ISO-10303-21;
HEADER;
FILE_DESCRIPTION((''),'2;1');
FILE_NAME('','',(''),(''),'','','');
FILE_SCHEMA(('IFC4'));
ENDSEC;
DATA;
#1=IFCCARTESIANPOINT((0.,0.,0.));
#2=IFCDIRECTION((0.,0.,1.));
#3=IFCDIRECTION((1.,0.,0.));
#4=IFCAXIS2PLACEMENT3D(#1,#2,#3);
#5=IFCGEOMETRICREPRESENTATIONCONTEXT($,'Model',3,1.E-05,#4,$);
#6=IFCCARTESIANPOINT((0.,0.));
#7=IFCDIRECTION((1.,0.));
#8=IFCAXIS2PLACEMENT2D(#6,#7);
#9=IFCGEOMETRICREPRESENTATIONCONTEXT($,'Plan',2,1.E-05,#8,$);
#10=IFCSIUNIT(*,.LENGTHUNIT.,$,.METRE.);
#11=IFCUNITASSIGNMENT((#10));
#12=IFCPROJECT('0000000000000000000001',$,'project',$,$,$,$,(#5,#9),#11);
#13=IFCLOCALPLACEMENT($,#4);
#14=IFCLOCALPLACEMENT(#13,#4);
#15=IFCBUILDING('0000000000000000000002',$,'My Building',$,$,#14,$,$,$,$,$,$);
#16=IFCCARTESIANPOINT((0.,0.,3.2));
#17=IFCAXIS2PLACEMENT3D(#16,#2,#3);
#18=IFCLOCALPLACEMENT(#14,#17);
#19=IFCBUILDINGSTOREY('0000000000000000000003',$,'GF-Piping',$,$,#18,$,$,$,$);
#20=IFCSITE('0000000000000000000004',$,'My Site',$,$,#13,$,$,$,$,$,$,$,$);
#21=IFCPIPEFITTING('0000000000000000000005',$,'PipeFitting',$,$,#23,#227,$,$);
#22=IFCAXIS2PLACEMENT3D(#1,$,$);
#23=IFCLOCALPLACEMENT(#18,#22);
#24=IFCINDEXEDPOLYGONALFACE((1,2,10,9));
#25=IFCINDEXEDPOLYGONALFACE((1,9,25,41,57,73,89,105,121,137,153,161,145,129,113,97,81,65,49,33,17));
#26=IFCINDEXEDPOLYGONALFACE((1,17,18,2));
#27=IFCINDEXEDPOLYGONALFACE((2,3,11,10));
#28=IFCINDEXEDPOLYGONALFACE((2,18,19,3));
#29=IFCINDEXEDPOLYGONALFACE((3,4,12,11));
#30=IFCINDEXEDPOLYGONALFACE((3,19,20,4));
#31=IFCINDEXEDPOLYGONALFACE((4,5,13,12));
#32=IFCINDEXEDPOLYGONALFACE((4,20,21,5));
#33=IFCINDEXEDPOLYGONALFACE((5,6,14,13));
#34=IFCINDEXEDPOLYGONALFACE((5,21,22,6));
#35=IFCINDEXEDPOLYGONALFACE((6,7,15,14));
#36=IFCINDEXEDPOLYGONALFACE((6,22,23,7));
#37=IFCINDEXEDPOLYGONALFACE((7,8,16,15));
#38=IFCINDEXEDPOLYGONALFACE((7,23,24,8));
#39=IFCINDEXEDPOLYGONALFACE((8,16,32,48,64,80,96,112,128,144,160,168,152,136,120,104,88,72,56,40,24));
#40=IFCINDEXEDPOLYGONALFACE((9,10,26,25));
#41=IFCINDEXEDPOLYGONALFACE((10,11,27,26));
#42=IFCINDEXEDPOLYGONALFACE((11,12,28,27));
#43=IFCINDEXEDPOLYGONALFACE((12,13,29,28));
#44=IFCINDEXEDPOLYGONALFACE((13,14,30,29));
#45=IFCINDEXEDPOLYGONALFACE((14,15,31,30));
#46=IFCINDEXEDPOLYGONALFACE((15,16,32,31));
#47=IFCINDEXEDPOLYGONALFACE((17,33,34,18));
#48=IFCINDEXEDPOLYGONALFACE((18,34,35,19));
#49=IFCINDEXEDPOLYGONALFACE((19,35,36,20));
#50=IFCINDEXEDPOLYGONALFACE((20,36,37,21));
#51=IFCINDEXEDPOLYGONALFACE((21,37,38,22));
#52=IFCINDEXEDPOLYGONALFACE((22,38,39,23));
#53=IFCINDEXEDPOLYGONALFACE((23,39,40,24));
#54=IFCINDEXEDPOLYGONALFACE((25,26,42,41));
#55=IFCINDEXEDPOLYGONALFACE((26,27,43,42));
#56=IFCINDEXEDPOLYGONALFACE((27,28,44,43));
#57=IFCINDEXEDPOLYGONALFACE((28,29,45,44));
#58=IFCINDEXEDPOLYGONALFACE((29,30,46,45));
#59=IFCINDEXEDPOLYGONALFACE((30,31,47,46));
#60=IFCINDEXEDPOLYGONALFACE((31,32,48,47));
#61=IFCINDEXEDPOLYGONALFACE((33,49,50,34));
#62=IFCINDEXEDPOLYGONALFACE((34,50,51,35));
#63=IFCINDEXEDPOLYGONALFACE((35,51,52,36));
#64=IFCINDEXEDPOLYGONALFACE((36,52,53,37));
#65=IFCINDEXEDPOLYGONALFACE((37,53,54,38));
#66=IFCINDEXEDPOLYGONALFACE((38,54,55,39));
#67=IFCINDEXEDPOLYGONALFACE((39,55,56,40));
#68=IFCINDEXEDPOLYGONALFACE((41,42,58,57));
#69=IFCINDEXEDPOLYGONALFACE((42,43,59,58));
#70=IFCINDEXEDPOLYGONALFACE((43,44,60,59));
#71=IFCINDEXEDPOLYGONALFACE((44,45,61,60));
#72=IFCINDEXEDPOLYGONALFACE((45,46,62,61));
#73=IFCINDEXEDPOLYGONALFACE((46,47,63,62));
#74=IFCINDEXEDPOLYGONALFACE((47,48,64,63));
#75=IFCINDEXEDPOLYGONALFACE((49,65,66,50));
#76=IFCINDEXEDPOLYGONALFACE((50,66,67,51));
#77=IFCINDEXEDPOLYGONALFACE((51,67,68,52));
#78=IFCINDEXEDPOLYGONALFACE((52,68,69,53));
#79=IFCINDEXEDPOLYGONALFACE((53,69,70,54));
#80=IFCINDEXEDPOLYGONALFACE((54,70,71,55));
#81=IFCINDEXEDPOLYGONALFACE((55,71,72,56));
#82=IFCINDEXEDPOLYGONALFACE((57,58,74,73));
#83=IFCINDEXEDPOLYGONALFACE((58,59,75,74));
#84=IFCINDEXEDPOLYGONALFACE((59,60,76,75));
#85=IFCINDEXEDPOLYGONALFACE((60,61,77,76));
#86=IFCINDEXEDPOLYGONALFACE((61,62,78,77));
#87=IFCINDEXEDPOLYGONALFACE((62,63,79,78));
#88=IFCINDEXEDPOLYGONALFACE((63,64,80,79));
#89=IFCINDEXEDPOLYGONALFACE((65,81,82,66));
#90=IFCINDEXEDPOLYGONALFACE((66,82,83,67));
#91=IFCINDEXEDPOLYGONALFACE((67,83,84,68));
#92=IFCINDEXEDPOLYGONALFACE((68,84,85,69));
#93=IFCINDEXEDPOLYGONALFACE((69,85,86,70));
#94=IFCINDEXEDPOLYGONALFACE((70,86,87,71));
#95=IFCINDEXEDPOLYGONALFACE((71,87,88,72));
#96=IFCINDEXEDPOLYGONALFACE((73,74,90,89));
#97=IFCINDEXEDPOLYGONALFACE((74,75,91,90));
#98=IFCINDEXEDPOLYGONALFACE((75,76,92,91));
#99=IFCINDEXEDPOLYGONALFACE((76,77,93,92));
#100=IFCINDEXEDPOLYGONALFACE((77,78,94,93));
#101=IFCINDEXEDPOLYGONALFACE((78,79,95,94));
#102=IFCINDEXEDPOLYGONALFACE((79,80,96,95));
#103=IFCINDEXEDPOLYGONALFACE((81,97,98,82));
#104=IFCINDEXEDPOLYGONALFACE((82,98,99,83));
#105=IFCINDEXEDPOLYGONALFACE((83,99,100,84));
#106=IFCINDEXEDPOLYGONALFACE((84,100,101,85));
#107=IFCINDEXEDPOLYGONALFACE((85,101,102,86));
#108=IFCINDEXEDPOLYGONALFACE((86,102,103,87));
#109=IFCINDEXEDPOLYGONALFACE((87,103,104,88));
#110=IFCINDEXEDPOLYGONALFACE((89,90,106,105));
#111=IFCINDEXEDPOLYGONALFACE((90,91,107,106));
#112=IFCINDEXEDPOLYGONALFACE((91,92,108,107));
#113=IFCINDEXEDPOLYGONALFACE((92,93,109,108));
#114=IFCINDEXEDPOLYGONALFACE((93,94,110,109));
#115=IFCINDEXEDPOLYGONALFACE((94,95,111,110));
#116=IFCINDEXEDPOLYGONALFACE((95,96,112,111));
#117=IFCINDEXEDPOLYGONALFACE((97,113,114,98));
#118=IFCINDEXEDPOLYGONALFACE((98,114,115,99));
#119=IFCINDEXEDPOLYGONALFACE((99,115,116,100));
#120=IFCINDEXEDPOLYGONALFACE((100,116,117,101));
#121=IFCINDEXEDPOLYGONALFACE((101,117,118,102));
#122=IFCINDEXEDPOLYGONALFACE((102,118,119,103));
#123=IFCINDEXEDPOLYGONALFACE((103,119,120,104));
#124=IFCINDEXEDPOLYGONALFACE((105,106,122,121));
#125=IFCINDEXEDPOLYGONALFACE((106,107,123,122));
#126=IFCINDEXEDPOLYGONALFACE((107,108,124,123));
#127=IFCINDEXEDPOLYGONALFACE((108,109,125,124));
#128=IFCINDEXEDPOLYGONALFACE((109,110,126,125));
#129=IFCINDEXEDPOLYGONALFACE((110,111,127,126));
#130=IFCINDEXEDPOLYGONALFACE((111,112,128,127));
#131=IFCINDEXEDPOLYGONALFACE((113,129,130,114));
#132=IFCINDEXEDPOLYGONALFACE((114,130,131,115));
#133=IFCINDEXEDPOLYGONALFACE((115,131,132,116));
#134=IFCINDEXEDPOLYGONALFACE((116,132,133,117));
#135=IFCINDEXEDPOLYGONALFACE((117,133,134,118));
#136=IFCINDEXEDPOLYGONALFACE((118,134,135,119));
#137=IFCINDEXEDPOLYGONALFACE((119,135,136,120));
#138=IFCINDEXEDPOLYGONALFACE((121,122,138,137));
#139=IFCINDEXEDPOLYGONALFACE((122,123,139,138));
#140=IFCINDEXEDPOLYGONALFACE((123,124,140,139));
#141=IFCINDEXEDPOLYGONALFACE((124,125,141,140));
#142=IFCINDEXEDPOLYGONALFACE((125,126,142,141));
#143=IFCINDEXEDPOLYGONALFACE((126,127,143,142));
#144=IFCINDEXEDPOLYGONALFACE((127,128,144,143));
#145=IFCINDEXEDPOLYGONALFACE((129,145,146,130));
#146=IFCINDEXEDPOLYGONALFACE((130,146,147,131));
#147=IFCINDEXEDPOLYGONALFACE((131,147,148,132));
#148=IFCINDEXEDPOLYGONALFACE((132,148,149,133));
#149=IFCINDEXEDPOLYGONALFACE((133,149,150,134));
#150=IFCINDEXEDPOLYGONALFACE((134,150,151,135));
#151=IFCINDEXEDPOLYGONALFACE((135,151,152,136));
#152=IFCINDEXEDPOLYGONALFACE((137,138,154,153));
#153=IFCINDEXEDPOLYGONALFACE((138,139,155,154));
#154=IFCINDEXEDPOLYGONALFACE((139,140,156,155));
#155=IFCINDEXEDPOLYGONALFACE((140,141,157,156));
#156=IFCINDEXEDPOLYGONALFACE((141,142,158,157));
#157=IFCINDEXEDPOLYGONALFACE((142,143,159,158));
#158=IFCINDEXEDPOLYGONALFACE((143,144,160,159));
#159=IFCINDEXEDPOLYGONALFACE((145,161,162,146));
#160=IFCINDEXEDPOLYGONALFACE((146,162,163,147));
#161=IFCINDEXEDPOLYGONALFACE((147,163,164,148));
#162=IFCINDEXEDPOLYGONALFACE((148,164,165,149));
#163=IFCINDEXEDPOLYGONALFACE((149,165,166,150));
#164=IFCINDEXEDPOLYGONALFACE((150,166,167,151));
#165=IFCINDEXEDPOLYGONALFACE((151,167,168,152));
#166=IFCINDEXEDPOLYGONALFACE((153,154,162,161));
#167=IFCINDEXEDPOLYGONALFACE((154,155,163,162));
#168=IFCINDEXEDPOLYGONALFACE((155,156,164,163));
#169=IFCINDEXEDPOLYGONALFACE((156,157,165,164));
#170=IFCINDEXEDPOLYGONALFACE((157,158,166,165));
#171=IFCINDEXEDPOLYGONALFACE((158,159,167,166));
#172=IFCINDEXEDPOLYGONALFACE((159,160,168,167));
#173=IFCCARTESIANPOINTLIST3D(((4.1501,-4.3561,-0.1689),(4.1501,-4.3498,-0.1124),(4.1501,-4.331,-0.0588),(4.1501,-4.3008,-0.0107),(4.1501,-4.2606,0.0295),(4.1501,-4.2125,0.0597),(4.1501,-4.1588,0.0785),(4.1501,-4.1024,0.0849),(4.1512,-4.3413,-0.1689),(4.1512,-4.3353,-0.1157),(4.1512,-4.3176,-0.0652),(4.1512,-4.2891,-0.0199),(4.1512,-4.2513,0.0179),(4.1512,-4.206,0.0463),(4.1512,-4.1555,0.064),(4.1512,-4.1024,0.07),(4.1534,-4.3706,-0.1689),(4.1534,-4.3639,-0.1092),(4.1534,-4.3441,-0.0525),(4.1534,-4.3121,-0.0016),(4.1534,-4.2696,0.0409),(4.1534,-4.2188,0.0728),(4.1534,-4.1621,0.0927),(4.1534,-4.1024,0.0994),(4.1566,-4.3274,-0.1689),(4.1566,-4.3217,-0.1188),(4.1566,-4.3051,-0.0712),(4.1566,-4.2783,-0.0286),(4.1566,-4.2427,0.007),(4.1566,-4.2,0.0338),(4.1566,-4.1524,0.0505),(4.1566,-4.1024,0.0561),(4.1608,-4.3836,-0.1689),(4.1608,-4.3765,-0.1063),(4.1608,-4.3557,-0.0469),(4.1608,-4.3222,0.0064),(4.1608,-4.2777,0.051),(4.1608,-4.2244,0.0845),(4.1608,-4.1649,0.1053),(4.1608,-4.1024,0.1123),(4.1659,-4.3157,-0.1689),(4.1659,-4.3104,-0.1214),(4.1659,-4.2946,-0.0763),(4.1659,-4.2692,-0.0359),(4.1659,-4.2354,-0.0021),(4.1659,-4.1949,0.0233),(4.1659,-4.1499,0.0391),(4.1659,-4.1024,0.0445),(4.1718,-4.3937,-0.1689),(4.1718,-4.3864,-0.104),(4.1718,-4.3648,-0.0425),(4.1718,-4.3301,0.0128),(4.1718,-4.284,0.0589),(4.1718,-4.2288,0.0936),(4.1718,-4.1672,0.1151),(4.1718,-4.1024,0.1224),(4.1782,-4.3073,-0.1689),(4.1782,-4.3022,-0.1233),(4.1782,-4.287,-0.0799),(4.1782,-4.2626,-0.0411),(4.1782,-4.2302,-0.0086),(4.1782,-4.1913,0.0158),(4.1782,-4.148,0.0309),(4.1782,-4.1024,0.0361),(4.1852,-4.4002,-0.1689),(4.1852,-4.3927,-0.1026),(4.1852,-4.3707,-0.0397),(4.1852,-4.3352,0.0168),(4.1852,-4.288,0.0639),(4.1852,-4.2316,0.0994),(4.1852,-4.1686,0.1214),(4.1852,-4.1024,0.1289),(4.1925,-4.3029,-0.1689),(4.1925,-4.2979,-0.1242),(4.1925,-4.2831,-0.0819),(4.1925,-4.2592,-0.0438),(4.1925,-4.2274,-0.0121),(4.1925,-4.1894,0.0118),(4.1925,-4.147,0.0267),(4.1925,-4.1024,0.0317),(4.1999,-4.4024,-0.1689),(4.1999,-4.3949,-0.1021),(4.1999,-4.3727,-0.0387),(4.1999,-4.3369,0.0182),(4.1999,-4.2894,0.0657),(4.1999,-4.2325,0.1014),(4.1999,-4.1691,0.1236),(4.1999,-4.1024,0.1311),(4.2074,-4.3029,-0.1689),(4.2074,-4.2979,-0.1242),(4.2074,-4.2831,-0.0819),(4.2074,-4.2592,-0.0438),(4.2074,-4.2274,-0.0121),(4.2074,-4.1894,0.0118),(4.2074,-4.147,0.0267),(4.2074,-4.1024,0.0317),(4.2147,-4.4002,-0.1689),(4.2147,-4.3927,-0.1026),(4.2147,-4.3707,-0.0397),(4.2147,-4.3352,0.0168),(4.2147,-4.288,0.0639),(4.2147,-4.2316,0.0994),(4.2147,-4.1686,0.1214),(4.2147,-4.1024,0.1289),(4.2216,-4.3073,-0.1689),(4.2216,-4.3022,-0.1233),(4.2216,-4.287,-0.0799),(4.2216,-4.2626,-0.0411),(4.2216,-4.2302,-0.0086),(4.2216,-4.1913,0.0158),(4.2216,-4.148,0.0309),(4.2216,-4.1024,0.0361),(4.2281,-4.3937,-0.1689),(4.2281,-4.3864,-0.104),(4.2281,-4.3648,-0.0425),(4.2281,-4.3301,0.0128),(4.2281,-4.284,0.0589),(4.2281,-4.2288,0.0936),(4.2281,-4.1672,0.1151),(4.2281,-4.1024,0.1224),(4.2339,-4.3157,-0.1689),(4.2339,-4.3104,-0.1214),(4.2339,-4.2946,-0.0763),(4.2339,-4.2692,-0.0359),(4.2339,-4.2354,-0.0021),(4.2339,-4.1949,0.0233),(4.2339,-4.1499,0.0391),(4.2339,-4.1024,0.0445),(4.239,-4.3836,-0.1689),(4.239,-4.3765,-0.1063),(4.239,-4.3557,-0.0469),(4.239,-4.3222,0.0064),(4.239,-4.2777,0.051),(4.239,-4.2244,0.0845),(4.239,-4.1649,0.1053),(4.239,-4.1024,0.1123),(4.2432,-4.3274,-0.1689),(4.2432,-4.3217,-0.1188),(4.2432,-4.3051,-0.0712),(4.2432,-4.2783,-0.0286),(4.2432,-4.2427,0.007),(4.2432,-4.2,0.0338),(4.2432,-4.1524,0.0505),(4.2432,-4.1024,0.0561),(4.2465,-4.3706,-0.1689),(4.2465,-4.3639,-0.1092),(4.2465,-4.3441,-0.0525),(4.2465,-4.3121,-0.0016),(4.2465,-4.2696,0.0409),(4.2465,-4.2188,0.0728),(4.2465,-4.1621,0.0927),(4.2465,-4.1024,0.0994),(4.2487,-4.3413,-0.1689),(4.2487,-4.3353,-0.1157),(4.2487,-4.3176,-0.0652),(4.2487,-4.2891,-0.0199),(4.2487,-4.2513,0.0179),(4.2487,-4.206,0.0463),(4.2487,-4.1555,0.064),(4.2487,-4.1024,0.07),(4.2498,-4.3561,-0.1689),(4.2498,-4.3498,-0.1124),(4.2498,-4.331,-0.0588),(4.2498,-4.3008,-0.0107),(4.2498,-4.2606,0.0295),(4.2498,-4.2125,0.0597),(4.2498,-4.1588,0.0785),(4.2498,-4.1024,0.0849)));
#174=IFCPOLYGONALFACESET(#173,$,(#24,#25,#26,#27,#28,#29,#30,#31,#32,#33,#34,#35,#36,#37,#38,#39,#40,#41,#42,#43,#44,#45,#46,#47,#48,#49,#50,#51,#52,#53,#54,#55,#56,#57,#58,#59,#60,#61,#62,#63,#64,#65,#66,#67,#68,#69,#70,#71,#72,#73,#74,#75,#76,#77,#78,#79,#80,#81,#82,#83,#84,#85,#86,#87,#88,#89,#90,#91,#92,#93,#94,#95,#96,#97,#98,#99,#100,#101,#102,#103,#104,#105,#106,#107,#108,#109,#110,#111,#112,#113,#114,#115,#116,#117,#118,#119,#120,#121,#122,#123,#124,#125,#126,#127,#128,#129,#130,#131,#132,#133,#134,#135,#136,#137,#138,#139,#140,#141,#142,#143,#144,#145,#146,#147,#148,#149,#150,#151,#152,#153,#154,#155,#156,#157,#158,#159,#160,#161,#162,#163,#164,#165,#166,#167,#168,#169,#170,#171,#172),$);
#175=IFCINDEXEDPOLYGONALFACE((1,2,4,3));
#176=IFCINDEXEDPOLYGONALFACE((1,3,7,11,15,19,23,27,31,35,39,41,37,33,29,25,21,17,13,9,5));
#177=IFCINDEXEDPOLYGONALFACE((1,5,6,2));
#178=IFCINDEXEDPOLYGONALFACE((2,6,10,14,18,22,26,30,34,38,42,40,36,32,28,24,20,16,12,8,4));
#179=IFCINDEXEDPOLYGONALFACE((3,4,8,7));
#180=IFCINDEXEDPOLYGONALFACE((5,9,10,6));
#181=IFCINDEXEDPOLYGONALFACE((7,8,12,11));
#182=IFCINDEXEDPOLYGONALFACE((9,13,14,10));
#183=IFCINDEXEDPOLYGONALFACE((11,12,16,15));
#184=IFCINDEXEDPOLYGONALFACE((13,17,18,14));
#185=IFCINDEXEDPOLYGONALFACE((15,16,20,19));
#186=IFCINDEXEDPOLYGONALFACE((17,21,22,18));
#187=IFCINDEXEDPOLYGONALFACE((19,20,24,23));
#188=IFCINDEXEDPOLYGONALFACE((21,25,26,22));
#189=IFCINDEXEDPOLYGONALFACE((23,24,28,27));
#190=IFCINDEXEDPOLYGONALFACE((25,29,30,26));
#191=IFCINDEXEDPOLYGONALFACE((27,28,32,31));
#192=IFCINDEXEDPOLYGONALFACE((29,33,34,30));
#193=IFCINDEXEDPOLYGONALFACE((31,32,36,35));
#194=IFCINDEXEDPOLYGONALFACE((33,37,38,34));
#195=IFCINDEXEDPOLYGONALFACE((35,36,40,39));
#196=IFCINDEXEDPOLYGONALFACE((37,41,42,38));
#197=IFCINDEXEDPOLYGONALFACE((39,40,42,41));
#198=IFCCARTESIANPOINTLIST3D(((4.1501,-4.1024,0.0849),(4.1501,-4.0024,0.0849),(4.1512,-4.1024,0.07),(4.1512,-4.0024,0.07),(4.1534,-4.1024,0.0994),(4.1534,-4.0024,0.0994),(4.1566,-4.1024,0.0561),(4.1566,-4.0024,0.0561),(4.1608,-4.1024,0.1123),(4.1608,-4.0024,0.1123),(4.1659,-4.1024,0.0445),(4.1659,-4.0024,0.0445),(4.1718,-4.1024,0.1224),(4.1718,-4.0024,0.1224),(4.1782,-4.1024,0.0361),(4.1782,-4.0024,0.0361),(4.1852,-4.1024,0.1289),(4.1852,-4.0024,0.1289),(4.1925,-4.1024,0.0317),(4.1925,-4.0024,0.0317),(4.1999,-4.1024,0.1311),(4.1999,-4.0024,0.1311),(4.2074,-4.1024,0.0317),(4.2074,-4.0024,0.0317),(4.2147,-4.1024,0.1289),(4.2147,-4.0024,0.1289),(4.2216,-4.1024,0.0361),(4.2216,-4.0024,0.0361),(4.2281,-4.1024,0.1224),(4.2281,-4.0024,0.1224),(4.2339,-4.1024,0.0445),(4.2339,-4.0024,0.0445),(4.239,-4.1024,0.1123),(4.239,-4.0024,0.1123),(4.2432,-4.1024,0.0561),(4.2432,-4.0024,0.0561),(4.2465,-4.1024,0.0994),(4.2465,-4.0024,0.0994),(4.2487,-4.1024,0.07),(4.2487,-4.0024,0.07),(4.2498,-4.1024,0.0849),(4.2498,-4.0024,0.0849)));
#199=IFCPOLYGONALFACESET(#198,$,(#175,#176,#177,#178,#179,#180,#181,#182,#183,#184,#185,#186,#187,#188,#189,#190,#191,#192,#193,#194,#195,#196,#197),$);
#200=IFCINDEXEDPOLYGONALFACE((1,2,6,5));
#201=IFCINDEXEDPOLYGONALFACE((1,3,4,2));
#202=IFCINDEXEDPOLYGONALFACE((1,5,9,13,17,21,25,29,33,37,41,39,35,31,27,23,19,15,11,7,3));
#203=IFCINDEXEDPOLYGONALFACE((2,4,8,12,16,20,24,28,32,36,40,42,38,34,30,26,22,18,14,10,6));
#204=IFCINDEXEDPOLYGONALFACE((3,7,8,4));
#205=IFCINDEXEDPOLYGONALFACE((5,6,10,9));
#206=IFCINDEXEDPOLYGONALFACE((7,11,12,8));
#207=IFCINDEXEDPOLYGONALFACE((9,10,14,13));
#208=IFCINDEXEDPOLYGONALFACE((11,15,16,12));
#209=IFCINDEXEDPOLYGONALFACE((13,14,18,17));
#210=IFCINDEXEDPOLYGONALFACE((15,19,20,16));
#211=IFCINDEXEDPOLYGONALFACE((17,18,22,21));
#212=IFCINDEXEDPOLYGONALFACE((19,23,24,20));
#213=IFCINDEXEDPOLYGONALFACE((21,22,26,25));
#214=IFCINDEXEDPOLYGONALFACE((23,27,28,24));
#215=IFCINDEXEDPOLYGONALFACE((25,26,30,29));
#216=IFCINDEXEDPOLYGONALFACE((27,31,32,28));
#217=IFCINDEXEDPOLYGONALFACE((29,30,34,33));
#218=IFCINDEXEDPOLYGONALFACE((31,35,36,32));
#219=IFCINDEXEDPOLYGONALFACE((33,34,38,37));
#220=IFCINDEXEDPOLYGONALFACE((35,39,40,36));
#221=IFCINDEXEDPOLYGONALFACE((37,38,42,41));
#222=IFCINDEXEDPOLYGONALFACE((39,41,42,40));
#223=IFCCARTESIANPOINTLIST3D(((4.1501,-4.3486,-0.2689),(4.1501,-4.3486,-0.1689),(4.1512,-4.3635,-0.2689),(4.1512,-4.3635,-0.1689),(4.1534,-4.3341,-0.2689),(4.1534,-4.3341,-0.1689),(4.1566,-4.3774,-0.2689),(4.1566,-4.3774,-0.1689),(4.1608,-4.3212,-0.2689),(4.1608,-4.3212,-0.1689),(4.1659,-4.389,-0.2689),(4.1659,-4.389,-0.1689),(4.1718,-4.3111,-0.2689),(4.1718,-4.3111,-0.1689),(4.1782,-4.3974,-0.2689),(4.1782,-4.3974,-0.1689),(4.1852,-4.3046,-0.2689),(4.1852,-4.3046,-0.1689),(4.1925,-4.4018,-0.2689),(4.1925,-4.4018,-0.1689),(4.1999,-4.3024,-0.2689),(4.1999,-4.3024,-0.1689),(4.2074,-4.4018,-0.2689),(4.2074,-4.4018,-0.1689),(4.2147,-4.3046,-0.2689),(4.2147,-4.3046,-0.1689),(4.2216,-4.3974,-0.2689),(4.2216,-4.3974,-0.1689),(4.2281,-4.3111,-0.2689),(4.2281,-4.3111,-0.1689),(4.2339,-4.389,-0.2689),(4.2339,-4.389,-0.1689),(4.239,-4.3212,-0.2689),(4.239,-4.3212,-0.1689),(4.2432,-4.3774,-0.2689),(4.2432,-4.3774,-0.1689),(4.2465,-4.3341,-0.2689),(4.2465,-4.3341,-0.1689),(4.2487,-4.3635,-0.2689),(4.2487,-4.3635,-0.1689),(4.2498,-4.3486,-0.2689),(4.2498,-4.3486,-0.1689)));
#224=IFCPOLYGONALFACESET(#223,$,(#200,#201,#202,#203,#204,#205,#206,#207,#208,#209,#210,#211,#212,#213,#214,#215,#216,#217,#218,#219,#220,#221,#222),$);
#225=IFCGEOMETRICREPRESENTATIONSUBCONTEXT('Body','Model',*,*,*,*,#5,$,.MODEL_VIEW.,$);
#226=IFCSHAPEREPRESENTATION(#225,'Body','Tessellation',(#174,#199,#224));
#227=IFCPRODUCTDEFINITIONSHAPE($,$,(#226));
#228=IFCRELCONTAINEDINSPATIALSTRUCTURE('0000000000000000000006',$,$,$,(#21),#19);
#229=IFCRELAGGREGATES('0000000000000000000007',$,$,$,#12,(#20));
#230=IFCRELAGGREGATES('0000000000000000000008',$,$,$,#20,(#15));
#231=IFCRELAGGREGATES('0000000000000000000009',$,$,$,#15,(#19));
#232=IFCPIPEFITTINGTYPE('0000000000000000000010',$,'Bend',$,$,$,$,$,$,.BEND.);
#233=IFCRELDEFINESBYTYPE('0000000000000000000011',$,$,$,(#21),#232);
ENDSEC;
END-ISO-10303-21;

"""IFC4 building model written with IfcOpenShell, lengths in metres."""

from ifc_helpers import new_model, entity, si_unit, frame, origin_with_axes, origin_2d_with_axis, place, context, subcontext, project, spatial, circle, extrude, source, transform, mapped, type_object, type_shapes, element, save


model = new_model("IFC4")

# Units and contexts
model_context = context("Model", 3, precision=1e-05, world=origin_with_axes())
plan_context = context("Plan", 2, precision=1e-05, world=origin_2d_with_axis())
body_context = subcontext(model_context, "Body", "Model", "MODEL_VIEW")
ifc_project = project(units=[si_unit("LENGTHUNIT", "METRE")], contexts=[model_context, plan_context])

# Site, building, storey
site_placement = place(None, origin_with_axes())
site = spatial("IfcSite", under=ifc_project, at=site_placement, Name="My Site")
building_placement = place(site_placement, origin_with_axes())
building = spatial("IfcBuilding", under=site, at=building_placement, Name="My Building")
storey_placement = place(building_placement, frame((0.0, 0.0, 3.2), z_axis=(0.0, 0.0, 1.0), x_axis=(1.0, 0.0, 0.0)))
storey = spatial("IfcBuildingStorey", under=building, at=storey_placement, Name="GF-Piping")

# Pipe fitting
pipe_fitting_type = type_object("IfcPipeFittingType", Name="Bend", PredefinedType="BEND")
shared_shape = source(origin_with_axes(), body_context, "Body", "SolidModel", [
    entity("IfcSweptDiskSolid", entity("IfcIndexedPolyCurve", entity("IfcCartesianPointList3D", [[0.0, 0.0, 0.1], [-0.0732, 0.0, 0.2768], [-0.25, 0.0, 0.35]]), [entity("IfcArcIndex", [1, 2, 3])]), 0.05),
    extrude(circle(Radius=0.05), origin_with_axes(), (0.0, 0.0, 1.0), 0.1),
    extrude(circle(Radius=0.05), frame((-0.25, 0.0, 0.35), z_axis=(-1.0, 0.0, 0.0), x_axis=(0.0, 0.0, -1.0)), (0.0, 0.0, 1.0), 0.1),
])
type_shapes(pipe_fitting_type, [shared_shape])
for number, where, z_axis, x_axis, name in (
    (1, (4.1999, -4.0024, 0.0811), (0.0, -1.0, 0.0), (0.0, 0.0, 1.0), "PipeFitting"),
):
    element("IfcPipeFitting", number, at=place(storey_placement, frame(where, z_axis=z_axis, x_axis=x_axis)), inside=storey, type_object=pipe_fitting_type, Name=name, context=body_context, shape_type="MappedRepresentation", body=[
        mapped(shared_shape, transform((0.0, 0.0, 0.0), x_axis=(1.0, 0.0, 0.0), y_axis=(0.0, 1.0, 0.0), z_axis=(0.0, 0.0, 1.0), scale=1.0)),
    ])

save(model, "model.ifc")
